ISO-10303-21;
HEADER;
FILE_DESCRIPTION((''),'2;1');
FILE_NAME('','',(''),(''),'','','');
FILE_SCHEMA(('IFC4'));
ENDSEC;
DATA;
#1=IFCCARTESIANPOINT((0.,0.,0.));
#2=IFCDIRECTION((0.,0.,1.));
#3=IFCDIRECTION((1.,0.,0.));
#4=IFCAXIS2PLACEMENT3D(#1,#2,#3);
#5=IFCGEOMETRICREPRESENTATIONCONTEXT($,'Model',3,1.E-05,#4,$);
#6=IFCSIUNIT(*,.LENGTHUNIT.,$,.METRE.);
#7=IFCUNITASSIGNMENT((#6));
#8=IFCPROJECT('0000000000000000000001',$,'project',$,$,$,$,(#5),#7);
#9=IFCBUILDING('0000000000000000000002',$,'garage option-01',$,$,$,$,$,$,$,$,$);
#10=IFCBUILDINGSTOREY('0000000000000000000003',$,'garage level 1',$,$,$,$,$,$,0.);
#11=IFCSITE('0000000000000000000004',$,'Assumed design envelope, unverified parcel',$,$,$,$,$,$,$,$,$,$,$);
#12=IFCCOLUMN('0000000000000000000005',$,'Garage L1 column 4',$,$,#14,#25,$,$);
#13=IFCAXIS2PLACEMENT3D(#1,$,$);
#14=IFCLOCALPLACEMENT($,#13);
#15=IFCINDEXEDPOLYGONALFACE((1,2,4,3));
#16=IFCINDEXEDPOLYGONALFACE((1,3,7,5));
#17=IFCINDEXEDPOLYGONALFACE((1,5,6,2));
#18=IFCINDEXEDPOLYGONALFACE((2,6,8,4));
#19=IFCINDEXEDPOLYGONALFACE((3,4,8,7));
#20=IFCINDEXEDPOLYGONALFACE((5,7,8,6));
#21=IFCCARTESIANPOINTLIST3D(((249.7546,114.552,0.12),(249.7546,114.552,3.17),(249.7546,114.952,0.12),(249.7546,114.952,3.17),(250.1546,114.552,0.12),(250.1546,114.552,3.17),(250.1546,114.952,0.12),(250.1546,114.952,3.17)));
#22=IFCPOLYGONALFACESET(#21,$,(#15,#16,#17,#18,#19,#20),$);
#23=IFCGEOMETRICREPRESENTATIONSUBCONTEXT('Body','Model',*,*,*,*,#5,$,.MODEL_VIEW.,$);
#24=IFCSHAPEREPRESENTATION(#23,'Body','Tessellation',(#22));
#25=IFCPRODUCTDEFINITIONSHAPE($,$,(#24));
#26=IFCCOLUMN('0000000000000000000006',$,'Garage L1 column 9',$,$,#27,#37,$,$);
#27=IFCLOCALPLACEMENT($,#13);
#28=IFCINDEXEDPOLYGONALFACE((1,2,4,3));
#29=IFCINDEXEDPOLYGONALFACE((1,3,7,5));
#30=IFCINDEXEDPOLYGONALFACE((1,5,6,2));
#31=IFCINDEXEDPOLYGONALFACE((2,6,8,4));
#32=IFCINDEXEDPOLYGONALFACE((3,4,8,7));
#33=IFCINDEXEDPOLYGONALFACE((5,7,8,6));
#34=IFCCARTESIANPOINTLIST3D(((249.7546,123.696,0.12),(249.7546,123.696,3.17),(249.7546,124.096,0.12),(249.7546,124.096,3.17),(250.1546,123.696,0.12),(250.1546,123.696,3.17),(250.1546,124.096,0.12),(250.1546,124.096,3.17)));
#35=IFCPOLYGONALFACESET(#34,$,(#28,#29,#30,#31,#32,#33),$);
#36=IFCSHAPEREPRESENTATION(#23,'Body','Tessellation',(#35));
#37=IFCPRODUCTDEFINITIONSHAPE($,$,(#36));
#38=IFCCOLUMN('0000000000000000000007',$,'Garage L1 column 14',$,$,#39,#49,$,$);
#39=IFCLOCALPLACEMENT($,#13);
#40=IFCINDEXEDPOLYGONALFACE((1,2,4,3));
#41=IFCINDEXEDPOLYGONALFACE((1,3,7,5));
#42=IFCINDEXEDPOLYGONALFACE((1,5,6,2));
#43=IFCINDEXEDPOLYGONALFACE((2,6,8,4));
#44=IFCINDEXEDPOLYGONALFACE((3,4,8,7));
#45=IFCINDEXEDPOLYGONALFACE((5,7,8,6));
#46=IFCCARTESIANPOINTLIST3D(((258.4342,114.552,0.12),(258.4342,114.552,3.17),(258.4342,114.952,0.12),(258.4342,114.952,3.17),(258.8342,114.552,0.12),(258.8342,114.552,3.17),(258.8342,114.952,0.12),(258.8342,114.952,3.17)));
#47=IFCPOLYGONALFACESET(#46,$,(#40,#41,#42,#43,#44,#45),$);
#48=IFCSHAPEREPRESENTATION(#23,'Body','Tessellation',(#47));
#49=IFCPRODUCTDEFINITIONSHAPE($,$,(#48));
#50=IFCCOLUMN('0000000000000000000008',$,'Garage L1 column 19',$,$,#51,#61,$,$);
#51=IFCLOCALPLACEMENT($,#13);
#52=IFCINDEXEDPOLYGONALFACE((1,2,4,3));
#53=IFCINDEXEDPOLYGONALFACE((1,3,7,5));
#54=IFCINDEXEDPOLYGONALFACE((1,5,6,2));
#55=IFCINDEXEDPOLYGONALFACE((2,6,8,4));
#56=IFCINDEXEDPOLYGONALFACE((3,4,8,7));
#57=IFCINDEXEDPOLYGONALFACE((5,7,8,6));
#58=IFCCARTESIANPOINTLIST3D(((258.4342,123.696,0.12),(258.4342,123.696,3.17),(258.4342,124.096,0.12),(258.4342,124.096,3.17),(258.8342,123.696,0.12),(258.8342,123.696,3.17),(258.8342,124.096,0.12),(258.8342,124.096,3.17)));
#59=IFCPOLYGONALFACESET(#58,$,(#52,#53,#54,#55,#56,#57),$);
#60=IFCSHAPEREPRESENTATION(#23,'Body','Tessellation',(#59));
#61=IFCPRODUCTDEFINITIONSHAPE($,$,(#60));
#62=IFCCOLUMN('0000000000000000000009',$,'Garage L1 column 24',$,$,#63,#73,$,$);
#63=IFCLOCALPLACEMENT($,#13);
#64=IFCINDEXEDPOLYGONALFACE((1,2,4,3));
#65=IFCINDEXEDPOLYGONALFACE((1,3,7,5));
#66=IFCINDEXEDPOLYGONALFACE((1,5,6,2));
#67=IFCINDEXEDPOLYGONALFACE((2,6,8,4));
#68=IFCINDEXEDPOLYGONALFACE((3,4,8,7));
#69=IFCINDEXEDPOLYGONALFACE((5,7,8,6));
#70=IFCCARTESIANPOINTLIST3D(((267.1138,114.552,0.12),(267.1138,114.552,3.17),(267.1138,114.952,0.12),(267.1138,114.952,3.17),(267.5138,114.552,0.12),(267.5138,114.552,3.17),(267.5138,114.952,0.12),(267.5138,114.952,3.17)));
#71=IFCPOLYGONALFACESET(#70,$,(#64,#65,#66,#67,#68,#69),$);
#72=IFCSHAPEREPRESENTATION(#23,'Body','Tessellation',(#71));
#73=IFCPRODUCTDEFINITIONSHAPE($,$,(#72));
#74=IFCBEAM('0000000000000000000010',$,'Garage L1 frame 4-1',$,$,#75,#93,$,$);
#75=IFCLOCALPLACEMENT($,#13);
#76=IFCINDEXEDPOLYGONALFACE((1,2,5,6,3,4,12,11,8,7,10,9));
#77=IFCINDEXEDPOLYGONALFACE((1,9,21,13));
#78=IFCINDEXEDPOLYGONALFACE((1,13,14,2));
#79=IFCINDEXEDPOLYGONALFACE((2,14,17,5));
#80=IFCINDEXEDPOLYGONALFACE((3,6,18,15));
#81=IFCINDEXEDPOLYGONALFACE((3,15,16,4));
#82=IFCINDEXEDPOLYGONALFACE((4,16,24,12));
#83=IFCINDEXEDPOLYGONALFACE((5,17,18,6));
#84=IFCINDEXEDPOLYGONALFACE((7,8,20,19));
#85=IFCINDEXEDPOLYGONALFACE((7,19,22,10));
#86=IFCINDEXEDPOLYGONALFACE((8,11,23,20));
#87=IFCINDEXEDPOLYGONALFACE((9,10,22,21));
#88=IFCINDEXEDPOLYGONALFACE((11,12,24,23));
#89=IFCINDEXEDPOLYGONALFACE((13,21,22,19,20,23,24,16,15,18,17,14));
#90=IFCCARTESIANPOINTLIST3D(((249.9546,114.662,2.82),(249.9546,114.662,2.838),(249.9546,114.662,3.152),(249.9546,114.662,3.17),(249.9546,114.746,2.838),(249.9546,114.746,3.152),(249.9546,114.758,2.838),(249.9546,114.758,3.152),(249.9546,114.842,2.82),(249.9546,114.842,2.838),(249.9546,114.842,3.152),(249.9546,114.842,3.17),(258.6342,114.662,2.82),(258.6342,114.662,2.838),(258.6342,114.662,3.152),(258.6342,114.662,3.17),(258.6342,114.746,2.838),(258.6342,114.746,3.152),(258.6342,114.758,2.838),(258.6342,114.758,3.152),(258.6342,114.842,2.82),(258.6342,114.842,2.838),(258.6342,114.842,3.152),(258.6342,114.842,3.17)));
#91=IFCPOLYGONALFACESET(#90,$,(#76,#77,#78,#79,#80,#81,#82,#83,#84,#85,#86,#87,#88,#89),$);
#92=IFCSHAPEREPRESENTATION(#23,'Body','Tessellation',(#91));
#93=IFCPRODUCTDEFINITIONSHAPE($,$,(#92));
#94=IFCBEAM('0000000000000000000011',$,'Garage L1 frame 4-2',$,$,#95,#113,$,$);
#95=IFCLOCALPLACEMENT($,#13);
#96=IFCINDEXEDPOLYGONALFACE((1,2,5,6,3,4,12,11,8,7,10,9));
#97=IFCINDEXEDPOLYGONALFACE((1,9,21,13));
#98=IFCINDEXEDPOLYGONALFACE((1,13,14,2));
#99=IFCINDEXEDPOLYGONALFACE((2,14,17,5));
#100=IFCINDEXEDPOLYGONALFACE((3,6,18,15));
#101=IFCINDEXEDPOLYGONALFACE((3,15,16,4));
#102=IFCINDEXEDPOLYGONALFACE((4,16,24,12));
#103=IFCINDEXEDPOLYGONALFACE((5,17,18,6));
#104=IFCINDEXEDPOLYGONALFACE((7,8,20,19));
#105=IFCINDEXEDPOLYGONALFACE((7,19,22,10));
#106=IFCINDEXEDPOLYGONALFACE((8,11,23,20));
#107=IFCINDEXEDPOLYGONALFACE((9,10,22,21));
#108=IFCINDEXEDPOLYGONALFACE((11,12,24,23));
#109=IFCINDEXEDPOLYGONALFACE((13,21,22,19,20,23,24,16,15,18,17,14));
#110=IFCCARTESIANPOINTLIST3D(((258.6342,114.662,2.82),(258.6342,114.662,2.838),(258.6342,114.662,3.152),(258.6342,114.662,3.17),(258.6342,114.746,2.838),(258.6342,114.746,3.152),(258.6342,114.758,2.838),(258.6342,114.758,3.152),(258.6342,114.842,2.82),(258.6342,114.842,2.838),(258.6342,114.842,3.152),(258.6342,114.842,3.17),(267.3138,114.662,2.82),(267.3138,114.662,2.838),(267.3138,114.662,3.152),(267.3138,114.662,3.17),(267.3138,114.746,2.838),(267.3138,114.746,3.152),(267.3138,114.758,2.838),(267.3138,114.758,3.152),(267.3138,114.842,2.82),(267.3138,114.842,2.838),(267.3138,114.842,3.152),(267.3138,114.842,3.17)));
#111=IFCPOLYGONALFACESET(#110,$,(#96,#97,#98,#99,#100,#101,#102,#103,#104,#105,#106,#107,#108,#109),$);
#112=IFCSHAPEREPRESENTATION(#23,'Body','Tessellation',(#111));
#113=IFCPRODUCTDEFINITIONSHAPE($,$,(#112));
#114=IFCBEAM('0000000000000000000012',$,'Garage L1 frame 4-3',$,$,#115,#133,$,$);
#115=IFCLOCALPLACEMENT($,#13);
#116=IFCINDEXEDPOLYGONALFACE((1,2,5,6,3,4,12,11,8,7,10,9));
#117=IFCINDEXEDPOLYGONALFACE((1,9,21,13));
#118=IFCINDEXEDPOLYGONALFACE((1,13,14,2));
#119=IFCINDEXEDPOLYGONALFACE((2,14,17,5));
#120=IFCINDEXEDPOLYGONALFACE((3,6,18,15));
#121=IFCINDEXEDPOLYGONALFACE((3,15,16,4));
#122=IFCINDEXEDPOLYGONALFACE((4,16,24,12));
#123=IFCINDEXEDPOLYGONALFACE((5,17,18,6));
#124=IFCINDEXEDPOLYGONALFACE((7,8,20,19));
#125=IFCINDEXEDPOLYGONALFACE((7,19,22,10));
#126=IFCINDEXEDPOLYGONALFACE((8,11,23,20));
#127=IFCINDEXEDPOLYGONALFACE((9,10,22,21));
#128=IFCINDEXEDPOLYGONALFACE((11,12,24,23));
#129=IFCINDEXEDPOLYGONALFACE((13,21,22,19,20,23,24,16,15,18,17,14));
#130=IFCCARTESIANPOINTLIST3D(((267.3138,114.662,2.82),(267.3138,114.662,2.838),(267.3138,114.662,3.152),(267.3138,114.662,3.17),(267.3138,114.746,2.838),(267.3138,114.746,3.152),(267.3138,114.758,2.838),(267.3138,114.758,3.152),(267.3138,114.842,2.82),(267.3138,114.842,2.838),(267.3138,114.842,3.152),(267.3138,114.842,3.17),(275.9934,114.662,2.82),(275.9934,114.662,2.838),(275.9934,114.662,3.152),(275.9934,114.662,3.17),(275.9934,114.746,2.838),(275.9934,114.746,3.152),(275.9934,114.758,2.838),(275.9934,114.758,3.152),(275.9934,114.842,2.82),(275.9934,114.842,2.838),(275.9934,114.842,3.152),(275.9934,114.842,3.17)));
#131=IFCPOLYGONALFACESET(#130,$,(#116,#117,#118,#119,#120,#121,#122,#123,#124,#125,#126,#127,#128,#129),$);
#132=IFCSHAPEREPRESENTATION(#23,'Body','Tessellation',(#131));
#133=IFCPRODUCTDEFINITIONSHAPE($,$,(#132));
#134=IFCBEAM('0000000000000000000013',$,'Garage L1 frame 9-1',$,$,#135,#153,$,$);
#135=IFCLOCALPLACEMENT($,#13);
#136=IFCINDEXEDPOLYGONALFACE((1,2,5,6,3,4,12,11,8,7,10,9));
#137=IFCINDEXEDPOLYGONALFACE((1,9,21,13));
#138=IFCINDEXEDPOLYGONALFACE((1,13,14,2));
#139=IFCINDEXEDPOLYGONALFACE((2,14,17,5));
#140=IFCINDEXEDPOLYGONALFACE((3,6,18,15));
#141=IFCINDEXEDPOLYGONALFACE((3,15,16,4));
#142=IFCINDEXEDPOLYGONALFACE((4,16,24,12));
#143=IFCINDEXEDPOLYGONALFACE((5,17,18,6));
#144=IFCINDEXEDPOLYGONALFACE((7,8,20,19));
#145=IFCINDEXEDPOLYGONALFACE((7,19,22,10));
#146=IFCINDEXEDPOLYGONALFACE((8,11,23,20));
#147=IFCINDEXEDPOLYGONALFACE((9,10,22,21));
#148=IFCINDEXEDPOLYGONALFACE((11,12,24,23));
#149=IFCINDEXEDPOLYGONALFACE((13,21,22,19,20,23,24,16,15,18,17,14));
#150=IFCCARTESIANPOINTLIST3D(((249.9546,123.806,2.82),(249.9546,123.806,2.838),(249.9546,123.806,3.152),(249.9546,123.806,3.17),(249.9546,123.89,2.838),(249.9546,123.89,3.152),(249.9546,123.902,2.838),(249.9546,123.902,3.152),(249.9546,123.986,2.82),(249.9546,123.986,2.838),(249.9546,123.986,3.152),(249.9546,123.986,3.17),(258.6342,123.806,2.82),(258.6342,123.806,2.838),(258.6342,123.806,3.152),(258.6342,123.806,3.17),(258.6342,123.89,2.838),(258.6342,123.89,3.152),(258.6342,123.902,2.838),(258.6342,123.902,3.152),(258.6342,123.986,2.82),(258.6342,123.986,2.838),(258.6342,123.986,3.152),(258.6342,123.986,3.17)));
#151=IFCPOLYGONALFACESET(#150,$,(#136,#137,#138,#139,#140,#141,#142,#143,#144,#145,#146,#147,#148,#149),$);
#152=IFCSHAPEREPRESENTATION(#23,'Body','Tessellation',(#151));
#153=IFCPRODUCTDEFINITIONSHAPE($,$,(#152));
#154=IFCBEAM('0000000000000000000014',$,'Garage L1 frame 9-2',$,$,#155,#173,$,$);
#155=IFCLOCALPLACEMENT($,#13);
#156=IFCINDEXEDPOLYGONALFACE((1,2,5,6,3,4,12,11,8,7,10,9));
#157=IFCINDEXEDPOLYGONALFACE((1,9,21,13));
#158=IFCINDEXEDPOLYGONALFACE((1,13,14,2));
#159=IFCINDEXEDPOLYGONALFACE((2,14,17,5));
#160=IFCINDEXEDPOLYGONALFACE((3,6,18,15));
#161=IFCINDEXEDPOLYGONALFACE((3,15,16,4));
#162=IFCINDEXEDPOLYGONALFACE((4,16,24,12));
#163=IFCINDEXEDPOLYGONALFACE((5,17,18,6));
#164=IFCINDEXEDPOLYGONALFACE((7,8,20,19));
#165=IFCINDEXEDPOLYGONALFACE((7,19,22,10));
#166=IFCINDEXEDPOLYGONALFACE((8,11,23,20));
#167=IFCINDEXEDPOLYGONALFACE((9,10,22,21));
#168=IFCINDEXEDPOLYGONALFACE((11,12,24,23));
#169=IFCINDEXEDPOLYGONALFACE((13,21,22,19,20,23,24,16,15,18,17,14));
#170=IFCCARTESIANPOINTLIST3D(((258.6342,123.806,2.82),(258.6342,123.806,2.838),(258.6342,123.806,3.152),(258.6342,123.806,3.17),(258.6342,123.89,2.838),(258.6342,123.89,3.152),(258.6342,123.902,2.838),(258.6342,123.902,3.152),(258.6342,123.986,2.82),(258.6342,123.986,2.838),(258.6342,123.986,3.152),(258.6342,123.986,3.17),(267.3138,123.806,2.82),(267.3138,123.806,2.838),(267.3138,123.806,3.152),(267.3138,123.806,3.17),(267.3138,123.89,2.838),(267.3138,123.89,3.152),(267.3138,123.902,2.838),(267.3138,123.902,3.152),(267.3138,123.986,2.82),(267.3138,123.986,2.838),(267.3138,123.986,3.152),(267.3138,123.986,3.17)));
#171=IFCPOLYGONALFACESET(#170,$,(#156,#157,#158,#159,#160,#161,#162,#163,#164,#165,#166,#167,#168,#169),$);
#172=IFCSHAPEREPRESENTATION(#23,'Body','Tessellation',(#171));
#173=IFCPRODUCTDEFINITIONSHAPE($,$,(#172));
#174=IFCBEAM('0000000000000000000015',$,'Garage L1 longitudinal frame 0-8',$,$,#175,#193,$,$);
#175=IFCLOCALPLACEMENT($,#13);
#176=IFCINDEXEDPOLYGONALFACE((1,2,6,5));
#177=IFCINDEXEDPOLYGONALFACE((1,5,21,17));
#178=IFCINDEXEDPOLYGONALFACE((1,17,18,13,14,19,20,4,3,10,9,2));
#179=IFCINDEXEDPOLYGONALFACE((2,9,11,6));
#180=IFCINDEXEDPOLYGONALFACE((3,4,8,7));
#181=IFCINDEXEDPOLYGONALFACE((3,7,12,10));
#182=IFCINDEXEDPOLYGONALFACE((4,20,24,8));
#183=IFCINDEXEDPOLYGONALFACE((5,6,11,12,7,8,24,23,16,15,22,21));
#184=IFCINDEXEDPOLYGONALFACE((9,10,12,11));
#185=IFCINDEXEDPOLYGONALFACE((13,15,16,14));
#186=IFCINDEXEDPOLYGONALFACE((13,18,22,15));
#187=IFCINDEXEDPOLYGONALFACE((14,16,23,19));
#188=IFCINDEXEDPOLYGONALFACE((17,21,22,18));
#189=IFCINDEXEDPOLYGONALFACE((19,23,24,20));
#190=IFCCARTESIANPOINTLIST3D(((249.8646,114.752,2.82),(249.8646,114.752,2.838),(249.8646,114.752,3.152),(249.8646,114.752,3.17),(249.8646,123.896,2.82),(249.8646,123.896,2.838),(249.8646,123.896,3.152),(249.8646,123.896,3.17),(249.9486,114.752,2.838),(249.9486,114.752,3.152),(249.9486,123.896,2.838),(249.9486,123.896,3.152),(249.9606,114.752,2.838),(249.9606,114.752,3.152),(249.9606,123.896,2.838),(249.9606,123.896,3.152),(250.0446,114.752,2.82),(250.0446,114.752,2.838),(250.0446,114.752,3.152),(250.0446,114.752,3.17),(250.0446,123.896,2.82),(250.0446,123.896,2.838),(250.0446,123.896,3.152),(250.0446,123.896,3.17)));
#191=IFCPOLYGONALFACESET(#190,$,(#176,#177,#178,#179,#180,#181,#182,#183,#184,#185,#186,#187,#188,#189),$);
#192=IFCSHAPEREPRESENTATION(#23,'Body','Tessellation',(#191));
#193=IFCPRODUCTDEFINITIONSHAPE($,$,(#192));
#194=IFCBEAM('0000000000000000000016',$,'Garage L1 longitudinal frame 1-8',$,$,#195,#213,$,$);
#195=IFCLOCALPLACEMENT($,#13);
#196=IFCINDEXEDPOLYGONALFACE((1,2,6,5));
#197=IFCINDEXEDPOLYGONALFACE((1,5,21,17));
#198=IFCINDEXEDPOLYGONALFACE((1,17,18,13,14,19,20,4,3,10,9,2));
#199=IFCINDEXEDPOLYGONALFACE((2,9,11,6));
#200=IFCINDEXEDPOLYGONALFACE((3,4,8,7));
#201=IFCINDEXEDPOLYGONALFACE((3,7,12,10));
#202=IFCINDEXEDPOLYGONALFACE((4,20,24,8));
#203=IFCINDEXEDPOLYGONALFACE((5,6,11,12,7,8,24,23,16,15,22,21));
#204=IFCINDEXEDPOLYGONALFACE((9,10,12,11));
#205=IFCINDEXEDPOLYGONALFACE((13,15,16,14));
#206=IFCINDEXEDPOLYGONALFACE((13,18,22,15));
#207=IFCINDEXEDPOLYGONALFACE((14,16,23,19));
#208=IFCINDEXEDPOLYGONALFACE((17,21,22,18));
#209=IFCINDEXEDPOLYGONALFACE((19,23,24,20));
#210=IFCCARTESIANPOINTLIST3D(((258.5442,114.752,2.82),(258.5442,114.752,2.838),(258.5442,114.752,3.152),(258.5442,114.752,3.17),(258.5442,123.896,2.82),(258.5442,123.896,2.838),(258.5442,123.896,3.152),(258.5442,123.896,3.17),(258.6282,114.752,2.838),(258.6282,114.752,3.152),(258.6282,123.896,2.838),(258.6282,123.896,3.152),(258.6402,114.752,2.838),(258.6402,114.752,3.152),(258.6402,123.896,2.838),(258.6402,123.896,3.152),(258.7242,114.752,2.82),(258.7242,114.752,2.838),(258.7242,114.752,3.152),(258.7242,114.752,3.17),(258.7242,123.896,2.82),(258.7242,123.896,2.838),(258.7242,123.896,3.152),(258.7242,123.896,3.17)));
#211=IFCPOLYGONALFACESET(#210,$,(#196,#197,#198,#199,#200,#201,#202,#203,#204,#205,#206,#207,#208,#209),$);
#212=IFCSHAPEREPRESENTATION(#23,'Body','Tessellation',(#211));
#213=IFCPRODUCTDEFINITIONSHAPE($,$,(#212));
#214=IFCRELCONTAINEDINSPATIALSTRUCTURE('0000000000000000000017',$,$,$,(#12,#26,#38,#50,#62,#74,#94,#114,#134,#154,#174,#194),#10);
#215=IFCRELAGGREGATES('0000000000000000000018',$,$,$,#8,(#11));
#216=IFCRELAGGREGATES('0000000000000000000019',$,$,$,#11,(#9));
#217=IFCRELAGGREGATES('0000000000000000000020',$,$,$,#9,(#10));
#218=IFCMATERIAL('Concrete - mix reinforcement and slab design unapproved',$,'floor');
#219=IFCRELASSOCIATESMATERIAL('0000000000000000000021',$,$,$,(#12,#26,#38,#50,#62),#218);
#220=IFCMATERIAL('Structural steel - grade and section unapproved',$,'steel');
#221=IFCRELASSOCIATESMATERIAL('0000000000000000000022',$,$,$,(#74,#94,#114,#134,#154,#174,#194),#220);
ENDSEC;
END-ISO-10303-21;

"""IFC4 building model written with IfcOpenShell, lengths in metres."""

from ifc_helpers import new_model, si_unit, frame, origin_with_axes, place, context, subcontext, project, spatial, rectangle, i_section, extrude, material, element, save


model = new_model("IFC4")

# Units and contexts
model_context = context("Model", 3, precision=1e-05, world=origin_with_axes())
body_context = subcontext(model_context, "Body", "Model", "MODEL_VIEW")
ifc_project = project(units=[si_unit("LENGTHUNIT", "METRE")], contexts=[model_context])

# Site, building, storey
site = spatial("IfcSite", under=ifc_project, Name="Assumed design envelope, unverified parcel")
building = spatial("IfcBuilding", under=site, Name="garage option-01")
storey = spatial("IfcBuildingStorey", under=building, Name="garage level 1", Elevation=0.0)

# Columns
ifc_material_1 = material(Name="Concrete - mix reinforcement and slab design unapproved", Category="floor")
for number, where, z_axis, x_axis, name in (
    (1, (249.9546, 114.752, 0.12), (0.0, 0.0, 1.0), (1.0, 0.0, 0.0), "Garage L1 column 4"),
    (2, (249.9546, 123.896, 0.12), (0.0, 0.0, 1.0), (1.0, 0.0, 0.0), "Garage L1 column 9"),
    (3, (258.6342, 114.752, 0.12), (0.0, 0.0, 1.0), (1.0, 0.0, 0.0), "Garage L1 column 14"),
    (4, (258.6342, 123.896, 0.12), (0.0, 0.0, 1.0), (1.0, 0.0, 0.0), "Garage L1 column 19"),
    (5, (267.3138, 114.752, 0.12), (0.0, 0.0, 1.0), (1.0, 0.0, 0.0), "Garage L1 column 24"),
):
    element("IfcColumn", number, at=place(None, frame(where, z_axis=z_axis, x_axis=x_axis)), inside=storey, material=ifc_material_1, Name=name, context=body_context, shape_type="SweptSolid", body=[
        extrude(rectangle(XDim=0.4, YDim=0.4), origin_with_axes(), (0.0, 0.0, 1.0), 3.05),
    ])

# Beams
ifc_material_2 = material(Name="Structural steel - grade and section unapproved", Category="steel")
beam_1_placement = place(None, frame((249.9546, 114.752, 2.995), z_axis=(1.0, 0.0, 0.0), x_axis=(0.0, 1.0, 0.0)))
element("IfcBeam", 6, at=beam_1_placement, inside=storey, material=ifc_material_2, Name="Garage L1 frame 4-1", context=body_context, shape_type="SweptSolid", body=[
    extrude(i_section(OverallWidth=0.18, OverallDepth=0.35, WebThickness=0.012, FlangeThickness=0.018, FilletRadius=0.0), origin_with_axes(), (0.0, 0.0, 1.0), 8.6796),
])
beam_2_placement = place(None, frame((258.6342, 114.752, 2.995), z_axis=(1.0, 0.0, 0.0), x_axis=(0.0, 1.0, 0.0)))
element("IfcBeam", 7, at=beam_2_placement, inside=storey, material=ifc_material_2, Name="Garage L1 frame 4-2", context=body_context, shape_type="SweptSolid", body=[
    extrude(i_section(OverallWidth=0.18, OverallDepth=0.35, WebThickness=0.012, FlangeThickness=0.018, FilletRadius=0.0), origin_with_axes(), (0.0, 0.0, 1.0), 8.6796),
])
beam_3_placement = place(None, frame((267.3138, 114.752, 2.995), z_axis=(1.0, 0.0, 0.0), x_axis=(0.0, 1.0, 0.0)))
element("IfcBeam", 8, at=beam_3_placement, inside=storey, material=ifc_material_2, Name="Garage L1 frame 4-3", context=body_context, shape_type="SweptSolid", body=[
    extrude(i_section(OverallWidth=0.18, OverallDepth=0.35, WebThickness=0.012, FlangeThickness=0.018, FilletRadius=0.0), origin_with_axes(), (0.0, 0.0, 1.0), 8.6796),
])
beam_4_placement = place(None, frame((249.9546, 123.896, 2.995), z_axis=(1.0, 0.0, 0.0), x_axis=(0.0, 1.0, 0.0)))
element("IfcBeam", 9, at=beam_4_placement, inside=storey, material=ifc_material_2, Name="Garage L1 frame 9-1", context=body_context, shape_type="SweptSolid", body=[
    extrude(i_section(OverallWidth=0.18, OverallDepth=0.35, WebThickness=0.012, FlangeThickness=0.018, FilletRadius=0.0), origin_with_axes(), (0.0, 0.0, 1.0), 8.6796),
])
beam_5_placement = place(None, frame((258.6342, 123.896, 2.995), z_axis=(1.0, 0.0, 0.0), x_axis=(0.0, 1.0, 0.0)))
element("IfcBeam", 10, at=beam_5_placement, inside=storey, material=ifc_material_2, Name="Garage L1 frame 9-2", context=body_context, shape_type="SweptSolid", body=[
    extrude(i_section(OverallWidth=0.18, OverallDepth=0.35, WebThickness=0.012, FlangeThickness=0.018, FilletRadius=0.0), origin_with_axes(), (0.0, 0.0, 1.0), 8.6796),
])
for number, where, z_axis, x_axis, name in (
    (11, (249.9546, 114.752, 2.995), (0.0, 1.0, 0.0), (-1.0, 0.0, 0.0), "Garage L1 longitudinal frame 0-8"),
    (12, (258.6342, 114.752, 2.995), (0.0, 1.0, 0.0), (-1.0, 0.0, 0.0), "Garage L1 longitudinal frame 1-8"),
):
    element("IfcBeam", number, at=place(None, frame(where, z_axis=z_axis, x_axis=x_axis)), inside=storey, material=ifc_material_2, Name=name, context=body_context, shape_type="SweptSolid", body=[
        extrude(i_section(OverallWidth=0.18, OverallDepth=0.35, WebThickness=0.012, FlangeThickness=0.018, FilletRadius=0.0), origin_with_axes(), (0.0, 0.0, 1.0), 9.144),
    ])

save(model, "model.ifc")
